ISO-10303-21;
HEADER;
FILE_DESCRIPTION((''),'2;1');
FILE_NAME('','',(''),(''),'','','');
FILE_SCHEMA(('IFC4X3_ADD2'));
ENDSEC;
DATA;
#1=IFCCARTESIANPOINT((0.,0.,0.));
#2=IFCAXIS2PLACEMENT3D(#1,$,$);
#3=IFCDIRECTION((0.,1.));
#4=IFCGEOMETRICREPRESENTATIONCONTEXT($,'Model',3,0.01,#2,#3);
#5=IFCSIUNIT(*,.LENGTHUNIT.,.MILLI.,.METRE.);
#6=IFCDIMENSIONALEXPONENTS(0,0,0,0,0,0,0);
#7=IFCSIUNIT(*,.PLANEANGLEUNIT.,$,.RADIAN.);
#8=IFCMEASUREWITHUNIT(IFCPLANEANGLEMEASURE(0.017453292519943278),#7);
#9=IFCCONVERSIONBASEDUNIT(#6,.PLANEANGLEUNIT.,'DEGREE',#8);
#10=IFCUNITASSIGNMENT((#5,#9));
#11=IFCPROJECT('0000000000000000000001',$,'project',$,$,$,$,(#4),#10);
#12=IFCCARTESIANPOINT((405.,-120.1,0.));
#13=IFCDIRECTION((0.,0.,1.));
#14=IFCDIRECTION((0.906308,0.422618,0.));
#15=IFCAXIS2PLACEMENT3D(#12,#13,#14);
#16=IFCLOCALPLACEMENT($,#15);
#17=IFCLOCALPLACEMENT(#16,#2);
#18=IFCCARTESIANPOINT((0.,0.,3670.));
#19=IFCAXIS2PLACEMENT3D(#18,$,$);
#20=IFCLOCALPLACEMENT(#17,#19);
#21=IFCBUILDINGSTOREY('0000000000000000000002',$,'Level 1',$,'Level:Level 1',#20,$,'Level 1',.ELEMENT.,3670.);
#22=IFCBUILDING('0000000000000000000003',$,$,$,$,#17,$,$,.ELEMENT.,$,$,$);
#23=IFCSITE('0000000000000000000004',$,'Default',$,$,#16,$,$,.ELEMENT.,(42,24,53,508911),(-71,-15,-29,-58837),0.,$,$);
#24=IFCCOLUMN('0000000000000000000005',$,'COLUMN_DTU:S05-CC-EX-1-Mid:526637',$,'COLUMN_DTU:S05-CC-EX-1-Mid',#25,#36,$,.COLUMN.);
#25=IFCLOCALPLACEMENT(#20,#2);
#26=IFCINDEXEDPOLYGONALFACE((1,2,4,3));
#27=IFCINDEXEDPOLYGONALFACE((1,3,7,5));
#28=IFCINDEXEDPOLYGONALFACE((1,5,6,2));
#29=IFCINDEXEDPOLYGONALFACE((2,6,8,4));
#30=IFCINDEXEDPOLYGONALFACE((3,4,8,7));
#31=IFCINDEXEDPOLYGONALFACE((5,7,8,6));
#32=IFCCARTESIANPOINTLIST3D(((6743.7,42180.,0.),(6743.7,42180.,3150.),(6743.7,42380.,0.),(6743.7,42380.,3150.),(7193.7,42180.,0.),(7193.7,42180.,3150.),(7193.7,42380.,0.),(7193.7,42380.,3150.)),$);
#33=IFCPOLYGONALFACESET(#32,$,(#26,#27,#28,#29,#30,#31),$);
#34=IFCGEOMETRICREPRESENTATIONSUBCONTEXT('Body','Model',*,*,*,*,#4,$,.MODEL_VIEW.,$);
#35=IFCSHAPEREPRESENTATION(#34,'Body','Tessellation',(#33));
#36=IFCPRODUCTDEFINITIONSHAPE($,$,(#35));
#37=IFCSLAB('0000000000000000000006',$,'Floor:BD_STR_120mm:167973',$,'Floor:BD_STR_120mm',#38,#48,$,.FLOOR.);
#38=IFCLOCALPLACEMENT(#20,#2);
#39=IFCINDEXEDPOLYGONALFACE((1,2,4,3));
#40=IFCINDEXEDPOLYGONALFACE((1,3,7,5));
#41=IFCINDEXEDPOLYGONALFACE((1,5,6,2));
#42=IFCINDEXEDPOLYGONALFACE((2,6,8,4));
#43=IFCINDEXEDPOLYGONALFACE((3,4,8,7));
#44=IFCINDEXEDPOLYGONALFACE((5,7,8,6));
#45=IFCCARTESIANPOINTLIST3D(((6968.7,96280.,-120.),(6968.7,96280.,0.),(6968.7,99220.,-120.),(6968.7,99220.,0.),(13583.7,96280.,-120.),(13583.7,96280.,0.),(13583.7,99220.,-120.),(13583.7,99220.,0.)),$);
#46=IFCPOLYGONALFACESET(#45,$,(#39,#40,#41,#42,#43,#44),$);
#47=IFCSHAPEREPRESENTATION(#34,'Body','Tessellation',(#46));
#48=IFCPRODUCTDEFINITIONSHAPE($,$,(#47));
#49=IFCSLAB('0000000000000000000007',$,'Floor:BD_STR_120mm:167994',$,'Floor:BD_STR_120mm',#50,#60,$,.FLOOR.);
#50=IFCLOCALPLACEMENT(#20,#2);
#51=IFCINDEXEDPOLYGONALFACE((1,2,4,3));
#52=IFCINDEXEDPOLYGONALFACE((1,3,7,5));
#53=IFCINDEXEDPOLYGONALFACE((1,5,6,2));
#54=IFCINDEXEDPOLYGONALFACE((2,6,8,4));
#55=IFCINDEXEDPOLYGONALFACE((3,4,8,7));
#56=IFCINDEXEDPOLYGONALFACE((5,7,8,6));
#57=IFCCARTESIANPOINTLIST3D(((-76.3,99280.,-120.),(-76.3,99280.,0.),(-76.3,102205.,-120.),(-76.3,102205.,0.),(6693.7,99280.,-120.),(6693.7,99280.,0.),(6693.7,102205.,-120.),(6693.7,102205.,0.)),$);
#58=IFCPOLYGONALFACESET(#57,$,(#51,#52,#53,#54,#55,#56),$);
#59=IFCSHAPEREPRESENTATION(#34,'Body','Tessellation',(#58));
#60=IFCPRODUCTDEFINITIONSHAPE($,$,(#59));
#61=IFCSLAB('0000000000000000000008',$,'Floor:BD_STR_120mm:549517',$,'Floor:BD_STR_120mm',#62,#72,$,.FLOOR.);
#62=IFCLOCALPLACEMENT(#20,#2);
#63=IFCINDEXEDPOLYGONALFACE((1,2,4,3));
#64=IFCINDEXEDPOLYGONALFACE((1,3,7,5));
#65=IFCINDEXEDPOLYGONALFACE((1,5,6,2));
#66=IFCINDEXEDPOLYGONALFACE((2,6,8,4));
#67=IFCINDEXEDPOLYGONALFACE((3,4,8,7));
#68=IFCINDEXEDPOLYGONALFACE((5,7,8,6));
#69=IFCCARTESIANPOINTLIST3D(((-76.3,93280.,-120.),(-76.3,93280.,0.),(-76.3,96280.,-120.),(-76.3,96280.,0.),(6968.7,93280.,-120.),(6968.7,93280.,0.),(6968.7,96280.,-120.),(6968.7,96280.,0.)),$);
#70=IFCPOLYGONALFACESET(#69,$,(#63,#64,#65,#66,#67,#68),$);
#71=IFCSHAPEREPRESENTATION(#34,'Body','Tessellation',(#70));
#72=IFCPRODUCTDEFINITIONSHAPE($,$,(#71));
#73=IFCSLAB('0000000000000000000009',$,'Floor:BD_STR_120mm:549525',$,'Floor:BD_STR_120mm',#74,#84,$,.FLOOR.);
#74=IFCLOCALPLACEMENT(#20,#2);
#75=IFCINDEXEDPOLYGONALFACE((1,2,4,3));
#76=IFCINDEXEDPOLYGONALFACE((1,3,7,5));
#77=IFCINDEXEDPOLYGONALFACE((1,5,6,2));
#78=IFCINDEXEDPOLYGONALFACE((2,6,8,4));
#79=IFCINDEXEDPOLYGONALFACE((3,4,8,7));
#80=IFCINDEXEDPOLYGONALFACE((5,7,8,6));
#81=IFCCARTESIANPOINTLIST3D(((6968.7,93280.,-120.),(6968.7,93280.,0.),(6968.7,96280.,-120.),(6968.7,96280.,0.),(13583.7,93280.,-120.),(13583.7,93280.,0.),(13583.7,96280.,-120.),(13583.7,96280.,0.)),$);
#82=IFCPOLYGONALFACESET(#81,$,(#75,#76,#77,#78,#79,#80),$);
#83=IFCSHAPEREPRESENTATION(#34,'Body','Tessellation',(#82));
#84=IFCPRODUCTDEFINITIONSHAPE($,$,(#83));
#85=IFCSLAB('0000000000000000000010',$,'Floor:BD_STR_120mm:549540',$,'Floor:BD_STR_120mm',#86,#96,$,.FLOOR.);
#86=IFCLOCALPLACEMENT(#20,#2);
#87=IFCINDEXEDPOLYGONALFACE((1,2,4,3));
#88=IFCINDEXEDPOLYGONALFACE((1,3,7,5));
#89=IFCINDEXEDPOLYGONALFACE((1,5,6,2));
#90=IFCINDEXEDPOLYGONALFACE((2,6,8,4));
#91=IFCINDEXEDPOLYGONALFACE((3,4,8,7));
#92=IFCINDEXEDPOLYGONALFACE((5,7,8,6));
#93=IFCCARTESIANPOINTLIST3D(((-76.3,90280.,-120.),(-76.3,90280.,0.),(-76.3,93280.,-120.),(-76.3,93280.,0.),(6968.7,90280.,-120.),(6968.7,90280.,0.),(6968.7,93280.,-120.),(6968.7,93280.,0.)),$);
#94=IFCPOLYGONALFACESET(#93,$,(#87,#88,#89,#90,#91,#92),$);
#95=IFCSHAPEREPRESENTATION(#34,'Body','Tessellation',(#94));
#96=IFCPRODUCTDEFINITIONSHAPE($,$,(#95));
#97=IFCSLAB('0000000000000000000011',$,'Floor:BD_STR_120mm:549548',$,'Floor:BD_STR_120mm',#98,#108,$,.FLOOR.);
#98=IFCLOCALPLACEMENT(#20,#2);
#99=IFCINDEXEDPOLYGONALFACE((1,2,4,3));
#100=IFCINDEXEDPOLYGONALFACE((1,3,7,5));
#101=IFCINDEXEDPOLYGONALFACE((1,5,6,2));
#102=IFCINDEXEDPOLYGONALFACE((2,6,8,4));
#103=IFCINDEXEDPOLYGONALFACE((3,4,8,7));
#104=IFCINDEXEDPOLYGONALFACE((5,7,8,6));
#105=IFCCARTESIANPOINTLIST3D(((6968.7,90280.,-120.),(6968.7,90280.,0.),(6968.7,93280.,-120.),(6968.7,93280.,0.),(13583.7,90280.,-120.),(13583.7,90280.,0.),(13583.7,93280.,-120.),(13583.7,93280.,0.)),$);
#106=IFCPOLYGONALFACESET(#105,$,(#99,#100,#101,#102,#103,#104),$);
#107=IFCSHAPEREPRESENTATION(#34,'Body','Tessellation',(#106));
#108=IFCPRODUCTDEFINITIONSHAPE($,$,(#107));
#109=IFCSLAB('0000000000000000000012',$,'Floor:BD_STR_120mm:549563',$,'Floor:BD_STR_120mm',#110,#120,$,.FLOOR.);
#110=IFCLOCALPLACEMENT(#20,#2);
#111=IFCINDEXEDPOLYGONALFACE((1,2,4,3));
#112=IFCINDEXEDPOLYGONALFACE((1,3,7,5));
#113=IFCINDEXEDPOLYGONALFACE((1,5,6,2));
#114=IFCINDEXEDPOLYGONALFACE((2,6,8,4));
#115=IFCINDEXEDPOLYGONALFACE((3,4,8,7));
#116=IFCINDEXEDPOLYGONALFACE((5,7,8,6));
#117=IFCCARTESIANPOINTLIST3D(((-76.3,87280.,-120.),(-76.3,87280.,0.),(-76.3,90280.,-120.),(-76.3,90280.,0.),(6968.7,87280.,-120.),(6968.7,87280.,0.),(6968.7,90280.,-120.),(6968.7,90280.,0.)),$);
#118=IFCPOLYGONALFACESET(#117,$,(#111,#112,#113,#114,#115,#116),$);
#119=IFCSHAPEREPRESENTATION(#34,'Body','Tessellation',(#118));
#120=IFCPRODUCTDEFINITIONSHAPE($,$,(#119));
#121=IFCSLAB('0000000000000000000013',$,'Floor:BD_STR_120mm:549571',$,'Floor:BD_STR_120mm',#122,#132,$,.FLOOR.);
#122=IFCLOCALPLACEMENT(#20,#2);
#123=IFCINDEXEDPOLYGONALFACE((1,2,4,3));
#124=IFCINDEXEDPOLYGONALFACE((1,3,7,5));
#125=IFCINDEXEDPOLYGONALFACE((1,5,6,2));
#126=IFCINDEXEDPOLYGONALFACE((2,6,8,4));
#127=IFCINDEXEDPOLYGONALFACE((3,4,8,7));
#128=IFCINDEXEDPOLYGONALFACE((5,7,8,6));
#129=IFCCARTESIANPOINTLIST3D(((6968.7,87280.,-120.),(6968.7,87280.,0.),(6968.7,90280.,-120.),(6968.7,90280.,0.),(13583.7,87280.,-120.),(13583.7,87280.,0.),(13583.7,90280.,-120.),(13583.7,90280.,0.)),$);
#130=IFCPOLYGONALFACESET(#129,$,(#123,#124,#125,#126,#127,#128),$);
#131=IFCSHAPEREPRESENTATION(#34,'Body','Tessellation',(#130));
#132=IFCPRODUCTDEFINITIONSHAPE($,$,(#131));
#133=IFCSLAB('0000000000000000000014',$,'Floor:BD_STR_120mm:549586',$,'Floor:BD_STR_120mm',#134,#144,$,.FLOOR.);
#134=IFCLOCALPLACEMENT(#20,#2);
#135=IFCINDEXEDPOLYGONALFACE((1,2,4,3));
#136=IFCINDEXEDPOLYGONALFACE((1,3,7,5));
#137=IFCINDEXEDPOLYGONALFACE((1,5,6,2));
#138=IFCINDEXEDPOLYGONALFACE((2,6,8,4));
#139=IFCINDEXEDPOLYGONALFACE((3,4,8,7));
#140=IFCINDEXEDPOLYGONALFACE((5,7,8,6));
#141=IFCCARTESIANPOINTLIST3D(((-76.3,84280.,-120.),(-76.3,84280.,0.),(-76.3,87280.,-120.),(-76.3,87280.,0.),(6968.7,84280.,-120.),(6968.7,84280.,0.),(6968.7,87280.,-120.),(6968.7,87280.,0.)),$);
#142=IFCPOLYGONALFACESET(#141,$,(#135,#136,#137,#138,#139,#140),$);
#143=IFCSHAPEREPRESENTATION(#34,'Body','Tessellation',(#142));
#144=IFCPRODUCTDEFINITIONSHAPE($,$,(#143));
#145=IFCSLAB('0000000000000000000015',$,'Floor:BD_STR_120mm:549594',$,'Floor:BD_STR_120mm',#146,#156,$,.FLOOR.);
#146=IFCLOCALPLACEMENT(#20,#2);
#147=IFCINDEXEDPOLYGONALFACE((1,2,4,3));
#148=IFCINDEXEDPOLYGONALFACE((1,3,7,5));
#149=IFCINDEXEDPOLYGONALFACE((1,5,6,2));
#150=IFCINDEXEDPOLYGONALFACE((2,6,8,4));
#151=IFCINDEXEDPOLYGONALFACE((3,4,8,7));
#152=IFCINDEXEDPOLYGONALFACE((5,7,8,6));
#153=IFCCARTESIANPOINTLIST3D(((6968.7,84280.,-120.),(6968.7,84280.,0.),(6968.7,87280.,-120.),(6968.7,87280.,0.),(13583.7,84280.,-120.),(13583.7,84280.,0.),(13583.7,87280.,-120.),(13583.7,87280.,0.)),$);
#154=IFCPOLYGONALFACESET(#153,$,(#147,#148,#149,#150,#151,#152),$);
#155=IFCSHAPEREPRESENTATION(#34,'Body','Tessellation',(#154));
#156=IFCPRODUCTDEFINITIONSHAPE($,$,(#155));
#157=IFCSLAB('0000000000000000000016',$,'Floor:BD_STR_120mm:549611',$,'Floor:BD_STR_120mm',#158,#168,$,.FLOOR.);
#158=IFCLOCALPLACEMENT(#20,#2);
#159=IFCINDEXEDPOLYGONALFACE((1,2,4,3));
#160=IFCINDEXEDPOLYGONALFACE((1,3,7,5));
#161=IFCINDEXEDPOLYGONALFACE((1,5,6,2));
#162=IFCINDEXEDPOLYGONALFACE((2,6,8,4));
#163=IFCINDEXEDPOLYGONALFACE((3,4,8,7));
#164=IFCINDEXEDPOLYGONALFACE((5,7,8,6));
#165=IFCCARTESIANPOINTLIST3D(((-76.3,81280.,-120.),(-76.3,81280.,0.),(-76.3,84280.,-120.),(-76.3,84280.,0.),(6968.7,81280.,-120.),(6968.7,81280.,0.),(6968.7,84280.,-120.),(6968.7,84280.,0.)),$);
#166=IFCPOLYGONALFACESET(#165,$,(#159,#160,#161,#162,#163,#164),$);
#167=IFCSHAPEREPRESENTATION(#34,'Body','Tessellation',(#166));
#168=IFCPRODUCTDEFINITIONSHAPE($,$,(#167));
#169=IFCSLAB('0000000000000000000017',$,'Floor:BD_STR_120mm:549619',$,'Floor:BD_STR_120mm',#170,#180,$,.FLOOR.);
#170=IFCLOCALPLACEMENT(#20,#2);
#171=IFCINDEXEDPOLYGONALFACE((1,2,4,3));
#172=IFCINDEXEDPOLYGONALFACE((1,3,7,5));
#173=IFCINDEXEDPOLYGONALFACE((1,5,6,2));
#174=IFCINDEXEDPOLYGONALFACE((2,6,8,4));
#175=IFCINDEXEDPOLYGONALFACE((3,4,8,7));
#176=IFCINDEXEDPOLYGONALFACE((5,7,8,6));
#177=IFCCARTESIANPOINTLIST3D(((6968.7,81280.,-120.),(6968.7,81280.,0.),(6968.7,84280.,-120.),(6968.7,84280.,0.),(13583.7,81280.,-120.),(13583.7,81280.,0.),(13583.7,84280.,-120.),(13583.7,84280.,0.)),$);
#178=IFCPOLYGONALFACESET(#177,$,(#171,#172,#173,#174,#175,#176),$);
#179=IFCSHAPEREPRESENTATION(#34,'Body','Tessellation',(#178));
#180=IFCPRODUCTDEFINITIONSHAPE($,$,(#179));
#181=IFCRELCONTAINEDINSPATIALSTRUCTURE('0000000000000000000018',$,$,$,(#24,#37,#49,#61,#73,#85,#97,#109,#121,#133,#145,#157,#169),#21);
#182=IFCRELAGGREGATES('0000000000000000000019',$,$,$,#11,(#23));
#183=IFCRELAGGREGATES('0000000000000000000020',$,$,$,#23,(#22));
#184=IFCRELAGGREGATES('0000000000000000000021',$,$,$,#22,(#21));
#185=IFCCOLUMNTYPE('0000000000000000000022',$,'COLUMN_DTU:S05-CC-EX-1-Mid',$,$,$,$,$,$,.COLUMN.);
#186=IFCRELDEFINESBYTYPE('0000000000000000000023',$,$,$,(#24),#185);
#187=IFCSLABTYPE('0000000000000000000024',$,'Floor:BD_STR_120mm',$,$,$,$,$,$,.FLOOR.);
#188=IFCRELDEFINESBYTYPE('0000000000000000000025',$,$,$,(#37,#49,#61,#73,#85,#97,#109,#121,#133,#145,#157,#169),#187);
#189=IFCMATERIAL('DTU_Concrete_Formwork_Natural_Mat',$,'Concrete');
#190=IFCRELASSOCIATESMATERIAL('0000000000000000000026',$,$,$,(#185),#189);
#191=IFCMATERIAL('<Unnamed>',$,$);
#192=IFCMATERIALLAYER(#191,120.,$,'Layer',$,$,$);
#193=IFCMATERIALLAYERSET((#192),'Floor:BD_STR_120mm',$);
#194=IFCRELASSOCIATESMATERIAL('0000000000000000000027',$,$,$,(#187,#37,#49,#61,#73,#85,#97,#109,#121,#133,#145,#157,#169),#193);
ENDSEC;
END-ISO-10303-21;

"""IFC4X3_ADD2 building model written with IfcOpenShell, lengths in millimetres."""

from ifc_helpers import new_model, entity, si_unit, converted_unit, direction, frame, frame_2d, origin, origin_2d_with_axis, place, context, subcontext, project, spatial, rectangle, extrude, source, transform, mapped, material, layer, layer_set, layer_usage, material_profile, profile_set, type_object, type_shapes, element, save


model = new_model("IFC4X3_ADD2")

# Units and contexts
model_context = context("Model", 3, precision=0.01, world=origin(), true_north=direction((0.0, 1.0)))
body_context = subcontext(model_context, "Body", "Model", "MODEL_VIEW")
ifc_project = project(units=[si_unit("LENGTHUNIT", "METRE", prefix="MILLI"), converted_unit("PLANEANGLEUNIT", "DEGREE", entity("IfcPlaneAngleMeasure", 0.017453292519943278), si_unit("PLANEANGLEUNIT", "RADIAN"), dimensions=[0, 0, 0, 0, 0, 0, 0])], contexts=[model_context])

# Site, building, storey
site_placement = place(None, frame((405.0, -120.1, 0.0), z_axis=(0.0, 0.0, 1.0), x_axis=(0.906308, 0.422618, 0.0)))
site = spatial("IfcSite", under=ifc_project, at=site_placement, Name="Default", CompositionType="ELEMENT", RefLatitude=(42, 24, 53, 508911), RefLongitude=(-71, -15, -29, -58837), RefElevation=0.0)
building_placement = place(site_placement, origin())
building = spatial("IfcBuilding", under=site, at=building_placement, CompositionType="ELEMENT")
storey_placement = place(building_placement, frame((0.0, 0.0, 3670.0)))
storey = spatial("IfcBuildingStorey", under=building, at=storey_placement, Name="Level 1", ObjectType="Level:Level 1", LongName="Level 1", CompositionType="ELEMENT", Elevation=3670.0)

# Column
ifc_material_1 = material(Name="DTU_Concrete_Formwork_Natural_Mat", Category="Concrete")
ifc_material_profile = material_profile(ifc_material_1, rectangle(XDim=200.0, YDim=450.0, at=origin_2d_with_axis()), Name="S05-CC-EX-1-Mid")
ifc_profile_set = profile_set([ifc_material_profile], Name="S05-CC-EX-1-Mid")
column_type = type_object("IfcColumnType", Name="COLUMN_DTU:S05-CC-EX-1-Mid", PredefinedType="COLUMN", material=ifc_profile_set)
shared_shape = source(origin(), body_context, "Body", "SweptSolid", [
    extrude(rectangle(XDim=200.0, YDim=450.0, at=frame_2d((0.0, 0.0), x_axis=(1.0, 0.0))), frame((6968.7, 42280.0, 3670.0), z_axis=(0.0, 0.0, 1.0), x_axis=(0.0, 1.0, 0.0)), (0.0, 0.0, 1.0), 3150.0),
])
type_shapes(column_type, [shared_shape])
column_placement = place(storey_placement, frame((0.0, 0.0, -3670.0)))
element("IfcColumn", 1, at=column_placement, inside=storey, type_object=column_type, Name="COLUMN_DTU:S05-CC-EX-1-Mid:526637", ObjectType="COLUMN_DTU:S05-CC-EX-1-Mid", PredefinedType="COLUMN", context=body_context, shape_type="MappedRepresentation", body=[
    mapped(shared_shape, transform((0.0, 0.0, 0.0), scale=1.0)),
])

# Slabs
ifc_material_2 = material(Name="<Unnamed>")
ifc_layer = layer(ifc_material_2, 120.0, Name="Layer")
ifc_layer_set = layer_set([ifc_layer], Name="Floor:BD_STR_120mm")
slab_type = type_object("IfcSlabType", Name="Floor:BD_STR_120mm", PredefinedType="FLOOR", material=ifc_layer_set)
ifc_layer_usage_1 = layer_usage(ifc_layer_set, "AXIS3", "POSITIVE", 0.0)
slab_1_placement = place(storey_placement, origin())
element("IfcSlab", 2, at=slab_1_placement, inside=storey, type_object=slab_type, material=ifc_layer_usage_1, Name="Floor:BD_STR_120mm:167973", ObjectType="Floor:BD_STR_120mm", PredefinedType="FLOOR", context=body_context, shape_type="SweptSolid", body=[
    extrude(rectangle(XDim=2940.0, YDim=6615.0, at=origin_2d_with_axis()), frame((10276.2, 97750.0, 0.0), z_axis=(0.0, 0.0, -1.0), x_axis=(0.0, 1.0, 0.0)), (0.0, 0.0, 1.0), 120.0),
])
ifc_layer_usage_2 = layer_usage(ifc_layer_set, "AXIS3", "POSITIVE", 0.0)
slab_2_placement = place(storey_placement, origin())
element("IfcSlab", 3, at=slab_2_placement, inside=storey, type_object=slab_type, material=ifc_layer_usage_2, Name="Floor:BD_STR_120mm:167994", ObjectType="Floor:BD_STR_120mm", PredefinedType="FLOOR", context=body_context, shape_type="SweptSolid", body=[
    extrude(rectangle(XDim=2925.0, YDim=6770.0, at=frame_2d((0.0, 0.0), x_axis=(1.0, 0.0))), frame((3308.7, 100742.5, 0.0), z_axis=(0.0, 0.0, -1.0), x_axis=(0.0, 1.0, 0.0)), (0.0, 0.0, 1.0), 120.0),
])
ifc_layer_usage_3 = layer_usage(ifc_layer_set, "AXIS3", "POSITIVE", 0.0)
slab_3_placement = place(storey_placement, origin())
element("IfcSlab", 4, at=slab_3_placement, inside=storey, type_object=slab_type, material=ifc_layer_usage_3, Name="Floor:BD_STR_120mm:549517", ObjectType="Floor:BD_STR_120mm", PredefinedType="FLOOR", context=body_context, shape_type="SweptSolid", body=[
    extrude(rectangle(XDim=3000.0, YDim=7045.0, at=frame_2d((0.0, 0.0), x_axis=(1.0, 0.0))), frame((3446.2, 94780.0, 0.0), z_axis=(0.0, 0.0, -1.0), x_axis=(0.0, 1.0, 0.0)), (0.0, 0.0, 1.0), 120.0),
])
ifc_layer_usage_4 = layer_usage(ifc_layer_set, "AXIS3", "POSITIVE", 0.0)
slab_4_placement = place(storey_placement, origin())
element("IfcSlab", 5, at=slab_4_placement, inside=storey, type_object=slab_type, material=ifc_layer_usage_4, Name="Floor:BD_STR_120mm:549525", ObjectType="Floor:BD_STR_120mm", PredefinedType="FLOOR", context=body_context, shape_type="SweptSolid", body=[
    extrude(rectangle(XDim=3000.0, YDim=6615.0, at=origin_2d_with_axis()), frame((10276.2, 94780.0, 0.0), z_axis=(0.0, 0.0, -1.0), x_axis=(0.0, 1.0, 0.0)), (0.0, 0.0, 1.0), 120.0),
])
ifc_layer_usage_5 = layer_usage(ifc_layer_set, "AXIS3", "POSITIVE", 0.0)
slab_5_placement = place(storey_placement, origin())
element("IfcSlab", 6, at=slab_5_placement, inside=storey, type_object=slab_type, material=ifc_layer_usage_5, Name="Floor:BD_STR_120mm:549540", ObjectType="Floor:BD_STR_120mm", PredefinedType="FLOOR", context=body_context, shape_type="SweptSolid", body=[
    extrude(rectangle(XDim=3000.0, YDim=7045.0, at=frame_2d((0.0, 0.0), x_axis=(1.0, 0.0))), frame((3446.2, 91780.0, 0.0), z_axis=(0.0, 0.0, -1.0), x_axis=(0.0, 1.0, 0.0)), (0.0, 0.0, 1.0), 120.0),
])
ifc_layer_usage_6 = layer_usage(ifc_layer_set, "AXIS3", "POSITIVE", 0.0)
slab_6_placement = place(storey_placement, origin())
element("IfcSlab", 7, at=slab_6_placement, inside=storey, type_object=slab_type, material=ifc_layer_usage_6, Name="Floor:BD_STR_120mm:549548", ObjectType="Floor:BD_STR_120mm", PredefinedType="FLOOR", context=body_context, shape_type="SweptSolid", body=[
    extrude(rectangle(XDim=3000.0, YDim=6615.0, at=origin_2d_with_axis()), frame((10276.2, 91780.0, 0.0), z_axis=(0.0, 0.0, -1.0), x_axis=(0.0, 1.0, 0.0)), (0.0, 0.0, 1.0), 120.0),
])
ifc_layer_usage_7 = layer_usage(ifc_layer_set, "AXIS3", "POSITIVE", 0.0)
slab_7_placement = place(storey_placement, origin())
element("IfcSlab", 8, at=slab_7_placement, inside=storey, type_object=slab_type, material=ifc_layer_usage_7, Name="Floor:BD_STR_120mm:549563", ObjectType="Floor:BD_STR_120mm", PredefinedType="FLOOR", context=body_context, shape_type="SweptSolid", body=[
    extrude(rectangle(XDim=3000.0, YDim=7045.0, at=frame_2d((0.0, 0.0), x_axis=(1.0, 0.0))), frame((3446.2, 88780.0, 0.0), z_axis=(0.0, 0.0, -1.0), x_axis=(0.0, 1.0, 0.0)), (0.0, 0.0, 1.0), 120.0),
])
ifc_layer_usage_8 = layer_usage(ifc_layer_set, "AXIS3", "POSITIVE", 0.0)
slab_8_placement = place(storey_placement, origin())
element("IfcSlab", 9, at=slab_8_placement, inside=storey, type_object=slab_type, material=ifc_layer_usage_8, Name="Floor:BD_STR_120mm:549571", ObjectType="Floor:BD_STR_120mm", PredefinedType="FLOOR", context=body_context, shape_type="SweptSolid", body=[
    extrude(rectangle(XDim=3000.0, YDim=6615.0, at=origin_2d_with_axis()), frame((10276.2, 88780.0, 0.0), z_axis=(0.0, 0.0, -1.0), x_axis=(0.0, 1.0, 0.0)), (0.0, 0.0, 1.0), 120.0),
])
ifc_layer_usage_9 = layer_usage(ifc_layer_set, "AXIS3", "POSITIVE", 0.0)
slab_9_placement = place(storey_placement, origin())
element("IfcSlab", 10, at=slab_9_placement, inside=storey, type_object=slab_type, material=ifc_layer_usage_9, Name="Floor:BD_STR_120mm:549586", ObjectType="Floor:BD_STR_120mm", PredefinedType="FLOOR", context=body_context, shape_type="SweptSolid", body=[
    extrude(rectangle(XDim=3000.0, YDim=7045.0, at=frame_2d((0.0, 0.0), x_axis=(1.0, 0.0))), frame((3446.2, 85780.0, 0.0), z_axis=(0.0, 0.0, -1.0), x_axis=(0.0, 1.0, 0.0)), (0.0, 0.0, 1.0), 120.0),
])
ifc_layer_usage_10 = layer_usage(ifc_layer_set, "AXIS3", "POSITIVE", 0.0)
slab_10_placement = place(storey_placement, origin())
element("IfcSlab", 11, at=slab_10_placement, inside=storey, type_object=slab_type, material=ifc_layer_usage_10, Name="Floor:BD_STR_120mm:549594", ObjectType="Floor:BD_STR_120mm", PredefinedType="FLOOR", context=body_context, shape_type="SweptSolid", body=[
    extrude(rectangle(XDim=3000.0, YDim=6615.0, at=origin_2d_with_axis()), frame((10276.2, 85780.0, 0.0), z_axis=(0.0, 0.0, -1.0), x_axis=(0.0, 1.0, 0.0)), (0.0, 0.0, 1.0), 120.0),
])
ifc_layer_usage_11 = layer_usage(ifc_layer_set, "AXIS3", "POSITIVE", 0.0)
slab_11_placement = place(storey_placement, origin())
element("IfcSlab", 12, at=slab_11_placement, inside=storey, type_object=slab_type, material=ifc_layer_usage_11, Name="Floor:BD_STR_120mm:549611", ObjectType="Floor:BD_STR_120mm", PredefinedType="FLOOR", context=body_context, shape_type="SweptSolid", body=[
    extrude(rectangle(XDim=3000.0, YDim=7045.0, at=frame_2d((0.0, 0.0), x_axis=(1.0, 0.0))), frame((3446.2, 82780.0, 0.0), z_axis=(0.0, 0.0, -1.0), x_axis=(0.0, 1.0, 0.0)), (0.0, 0.0, 1.0), 120.0),
])
ifc_layer_usage_12 = layer_usage(ifc_layer_set, "AXIS3", "POSITIVE", 0.0)
slab_12_placement = place(storey_placement, origin())
element("IfcSlab", 13, at=slab_12_placement, inside=storey, type_object=slab_type, material=ifc_layer_usage_12, Name="Floor:BD_STR_120mm:549619", ObjectType="Floor:BD_STR_120mm", PredefinedType="FLOOR", context=body_context, shape_type="SweptSolid", body=[
    extrude(rectangle(XDim=3000.0, YDim=6615.0, at=origin_2d_with_axis()), frame((10276.2, 82780.0, 0.0), z_axis=(0.0, 0.0, -1.0), x_axis=(0.0, 1.0, 0.0)), (0.0, 0.0, 1.0), 120.0),
])

save(model, "model.ifc")
